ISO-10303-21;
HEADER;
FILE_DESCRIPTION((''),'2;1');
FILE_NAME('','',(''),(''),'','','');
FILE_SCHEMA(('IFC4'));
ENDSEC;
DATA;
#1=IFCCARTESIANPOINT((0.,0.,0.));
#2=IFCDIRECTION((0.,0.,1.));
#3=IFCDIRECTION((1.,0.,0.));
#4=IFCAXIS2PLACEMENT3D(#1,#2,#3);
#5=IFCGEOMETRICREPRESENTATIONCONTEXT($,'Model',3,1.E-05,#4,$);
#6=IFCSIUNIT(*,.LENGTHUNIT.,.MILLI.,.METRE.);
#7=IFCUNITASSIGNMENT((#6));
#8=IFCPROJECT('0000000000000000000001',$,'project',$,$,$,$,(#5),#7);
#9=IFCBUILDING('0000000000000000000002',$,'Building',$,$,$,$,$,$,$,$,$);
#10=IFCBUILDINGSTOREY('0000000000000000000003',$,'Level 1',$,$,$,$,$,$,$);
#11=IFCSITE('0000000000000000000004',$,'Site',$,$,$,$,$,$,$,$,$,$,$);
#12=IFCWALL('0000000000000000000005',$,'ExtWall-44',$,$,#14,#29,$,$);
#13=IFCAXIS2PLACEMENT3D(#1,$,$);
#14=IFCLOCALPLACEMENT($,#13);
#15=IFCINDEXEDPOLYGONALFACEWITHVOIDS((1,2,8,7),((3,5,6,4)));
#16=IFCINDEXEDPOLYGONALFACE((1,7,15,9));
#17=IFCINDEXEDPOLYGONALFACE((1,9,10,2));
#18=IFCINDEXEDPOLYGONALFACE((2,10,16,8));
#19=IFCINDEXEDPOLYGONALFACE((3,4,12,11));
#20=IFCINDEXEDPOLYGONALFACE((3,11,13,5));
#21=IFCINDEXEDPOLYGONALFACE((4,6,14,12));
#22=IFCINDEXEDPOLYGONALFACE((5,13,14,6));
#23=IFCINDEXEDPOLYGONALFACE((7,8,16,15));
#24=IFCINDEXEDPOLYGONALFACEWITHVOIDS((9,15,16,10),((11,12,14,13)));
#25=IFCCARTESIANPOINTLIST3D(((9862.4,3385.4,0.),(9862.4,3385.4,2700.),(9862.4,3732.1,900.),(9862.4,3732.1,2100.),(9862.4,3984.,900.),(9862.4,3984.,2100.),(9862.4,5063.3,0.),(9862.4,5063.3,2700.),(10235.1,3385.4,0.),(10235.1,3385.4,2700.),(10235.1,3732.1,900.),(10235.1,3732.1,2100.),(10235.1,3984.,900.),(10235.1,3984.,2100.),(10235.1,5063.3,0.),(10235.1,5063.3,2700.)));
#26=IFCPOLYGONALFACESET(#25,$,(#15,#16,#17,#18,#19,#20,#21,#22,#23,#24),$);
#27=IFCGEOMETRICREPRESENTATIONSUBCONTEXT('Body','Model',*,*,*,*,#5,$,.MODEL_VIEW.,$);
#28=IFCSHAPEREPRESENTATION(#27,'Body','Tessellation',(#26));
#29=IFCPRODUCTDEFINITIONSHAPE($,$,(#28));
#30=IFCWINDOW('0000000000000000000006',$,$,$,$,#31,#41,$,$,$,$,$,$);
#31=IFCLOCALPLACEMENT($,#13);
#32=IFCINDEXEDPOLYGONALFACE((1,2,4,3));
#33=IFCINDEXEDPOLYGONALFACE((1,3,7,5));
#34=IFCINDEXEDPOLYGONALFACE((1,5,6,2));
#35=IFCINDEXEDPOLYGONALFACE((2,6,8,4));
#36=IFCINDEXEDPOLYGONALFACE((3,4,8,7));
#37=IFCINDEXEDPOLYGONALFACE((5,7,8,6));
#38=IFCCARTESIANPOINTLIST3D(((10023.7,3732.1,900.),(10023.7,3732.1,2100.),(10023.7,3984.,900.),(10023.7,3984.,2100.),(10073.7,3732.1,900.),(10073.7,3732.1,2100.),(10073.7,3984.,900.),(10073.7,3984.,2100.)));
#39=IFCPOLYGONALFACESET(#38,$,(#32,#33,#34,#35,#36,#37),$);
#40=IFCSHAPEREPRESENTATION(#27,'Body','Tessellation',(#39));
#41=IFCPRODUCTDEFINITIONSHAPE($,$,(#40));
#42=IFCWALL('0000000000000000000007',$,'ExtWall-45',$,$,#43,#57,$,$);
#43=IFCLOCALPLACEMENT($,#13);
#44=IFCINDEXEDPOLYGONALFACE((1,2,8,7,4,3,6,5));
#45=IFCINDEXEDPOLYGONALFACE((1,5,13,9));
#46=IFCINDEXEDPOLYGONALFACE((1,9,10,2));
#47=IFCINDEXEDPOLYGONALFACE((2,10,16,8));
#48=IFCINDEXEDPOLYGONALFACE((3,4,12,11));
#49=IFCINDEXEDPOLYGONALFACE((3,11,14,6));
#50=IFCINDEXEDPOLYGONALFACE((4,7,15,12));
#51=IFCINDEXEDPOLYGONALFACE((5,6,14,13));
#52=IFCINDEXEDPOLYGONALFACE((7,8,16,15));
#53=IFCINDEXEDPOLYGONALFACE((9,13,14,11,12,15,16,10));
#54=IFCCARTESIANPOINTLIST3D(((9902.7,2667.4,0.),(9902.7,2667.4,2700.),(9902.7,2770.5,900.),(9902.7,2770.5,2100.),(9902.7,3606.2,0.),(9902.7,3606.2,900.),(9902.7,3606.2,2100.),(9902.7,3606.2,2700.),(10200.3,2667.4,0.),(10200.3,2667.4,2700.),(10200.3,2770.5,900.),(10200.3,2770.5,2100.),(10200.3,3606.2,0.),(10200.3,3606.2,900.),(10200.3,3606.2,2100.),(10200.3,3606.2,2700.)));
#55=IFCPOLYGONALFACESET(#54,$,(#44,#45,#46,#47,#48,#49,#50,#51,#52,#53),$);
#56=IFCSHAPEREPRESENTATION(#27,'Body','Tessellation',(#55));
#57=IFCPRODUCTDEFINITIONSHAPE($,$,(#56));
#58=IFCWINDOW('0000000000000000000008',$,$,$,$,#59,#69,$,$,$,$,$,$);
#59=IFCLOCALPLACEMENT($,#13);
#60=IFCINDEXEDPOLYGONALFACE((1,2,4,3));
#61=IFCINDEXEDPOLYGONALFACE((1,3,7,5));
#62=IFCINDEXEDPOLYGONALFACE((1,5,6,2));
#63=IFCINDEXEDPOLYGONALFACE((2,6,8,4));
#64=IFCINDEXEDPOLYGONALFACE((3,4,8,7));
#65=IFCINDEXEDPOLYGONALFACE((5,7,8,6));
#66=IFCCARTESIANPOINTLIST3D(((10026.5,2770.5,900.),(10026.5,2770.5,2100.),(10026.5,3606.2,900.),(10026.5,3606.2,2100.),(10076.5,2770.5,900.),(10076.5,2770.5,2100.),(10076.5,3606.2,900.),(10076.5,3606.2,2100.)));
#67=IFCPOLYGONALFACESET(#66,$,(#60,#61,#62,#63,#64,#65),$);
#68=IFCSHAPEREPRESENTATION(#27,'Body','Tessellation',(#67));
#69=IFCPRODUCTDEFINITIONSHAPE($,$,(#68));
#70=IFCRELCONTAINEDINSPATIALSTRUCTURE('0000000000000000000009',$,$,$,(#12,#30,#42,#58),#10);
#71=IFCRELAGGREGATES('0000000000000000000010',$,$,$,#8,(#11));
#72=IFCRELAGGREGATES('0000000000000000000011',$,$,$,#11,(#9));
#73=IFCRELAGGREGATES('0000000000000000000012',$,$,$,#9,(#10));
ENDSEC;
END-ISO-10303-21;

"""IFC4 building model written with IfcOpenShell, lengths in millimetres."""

from ifc_helpers import new_model, si_unit, frame, origin_with_axes, place, context, subcontext, project, spatial, indexed_curve, outline, extrude, element, fill, save


model = new_model("IFC4")

# Units and contexts
model_context = context("Model", 3, precision=1e-05, world=origin_with_axes())
body_context = subcontext(model_context, "Body", "Model", "MODEL_VIEW")
ifc_project = project(units=[si_unit("LENGTHUNIT", "METRE", prefix="MILLI")], contexts=[model_context])

# Site, building, storey
site = spatial("IfcSite", under=ifc_project, Name="Site")
building = spatial("IfcBuilding", under=site, Name="Building")
storey = spatial("IfcBuildingStorey", under=building, Name="Level 1")

# Walls, openings, windows
wall_1_placement = place(None, frame((10048.7, 3385.4, 0.0), z_axis=(0.0, 0.0, 1.0), x_axis=(0.0, 1.0, 0.0)))
wall_1 = element("IfcWall", 1, at=wall_1_placement, inside=storey, Name="ExtWall-44", context=body_context, shape_type="SweptSolid", body=[
    extrude(outline(indexed_curve([(0.0, 0.0), (0.0, 372.8), (1677.8, 372.8), (1677.8, 0.0), (0.0, 0.0)], self_intersect=False)), frame((0.0, -186.4, 0.0), z_axis=(0.0, 0.0, 1.0), x_axis=(1.0, 0.0, 0.0)), (0.0, 0.0, 1.0), 2700.0),
])
opening_1_placement = place(wall_1_placement, frame((346.7, 0.0, 900.0), z_axis=(0.0, 0.0, 1.0), x_axis=(1.0, 0.0, 0.0)))
opening_1 = element("IfcOpeningElement", 2, at=opening_1_placement, cuts=wall_1, context=body_context, shape_type="SweptSolid", body=[
    extrude(outline(indexed_curve([(0.0, 0.0), (0.0, 472.8), (251.9, 472.8), (251.9, 0.0), (0.0, 0.0)], self_intersect=False)), frame((0.0, -236.4, 0.0), z_axis=(0.0, 0.0, 1.0), x_axis=(1.0, 0.0, 0.0)), (0.0, 0.0, 1.0), 1200.0),
])
window_1_placement = place(opening_1_placement, frame((0.0, 0.0, 0.0), z_axis=(0.0, 0.0, 1.0), x_axis=(1.0, 0.0, 0.0)))
window_1 = element("IfcWindow", 3, at=window_1_placement, inside=storey, context=body_context, shape_type="SweptSolid", body=[
    extrude(outline(indexed_curve([(0.0, 0.0), (0.0, 50.0), (251.9, 50.0), (251.9, 0.0), (0.0, 0.0)], self_intersect=False)), frame((0.0, -25.0, 0.0), z_axis=(0.0, 0.0, 1.0), x_axis=(1.0, 0.0, 0.0)), (0.0, 0.0, 1.0), 1200.0),
])
fill(opening_1, window_1)
wall_2_placement = place(None, frame((10051.5, 2667.4, 0.0), z_axis=(0.0, 0.0, 1.0), x_axis=(0.0, 1.0, 0.0)))
wall_2 = element("IfcWall", 4, at=wall_2_placement, inside=storey, Name="ExtWall-45", context=body_context, shape_type="SweptSolid", body=[
    extrude(outline(indexed_curve([(0.0, 0.0), (0.0, 297.7), (938.7, 297.7), (938.7, 0.0), (0.0, 0.0)], self_intersect=False)), frame((0.0, -148.8, 0.0), z_axis=(0.0, 0.0, 1.0), x_axis=(1.0, 0.0, 0.0)), (0.0, 0.0, 1.0), 2700.0),
])
opening_2_placement = place(wall_2_placement, frame((103.0, 0.0, 900.0), z_axis=(0.0, 0.0, 1.0), x_axis=(1.0, 0.0, 0.0)))
opening_2 = element("IfcOpeningElement", 5, at=opening_2_placement, cuts=wall_2, context=body_context, shape_type="SweptSolid", body=[
    extrude(outline(indexed_curve([(0.0, 0.0), (0.0, 397.7), (835.7, 397.7), (835.7, 0.0), (0.0, 0.0)], self_intersect=False)), frame((0.0, -198.8, 0.0), z_axis=(0.0, 0.0, 1.0), x_axis=(1.0, 0.0, 0.0)), (0.0, 0.0, 1.0), 1200.0),
])
window_2_placement = place(opening_2_placement, frame((0.0, 0.0, 0.0), z_axis=(0.0, 0.0, 1.0), x_axis=(1.0, 0.0, 0.0)))
window_2 = element("IfcWindow", 6, at=window_2_placement, inside=storey, context=body_context, shape_type="SweptSolid", body=[
    extrude(outline(indexed_curve([(0.0, 0.0), (0.0, 50.0), (835.7, 50.0), (835.7, 0.0), (0.0, 0.0)], self_intersect=False)), frame((0.0, -25.0, 0.0), z_axis=(0.0, 0.0, 1.0), x_axis=(1.0, 0.0, 0.0)), (0.0, 0.0, 1.0), 1200.0),
])
fill(opening_2, window_2)

save(model, "model.ifc")
